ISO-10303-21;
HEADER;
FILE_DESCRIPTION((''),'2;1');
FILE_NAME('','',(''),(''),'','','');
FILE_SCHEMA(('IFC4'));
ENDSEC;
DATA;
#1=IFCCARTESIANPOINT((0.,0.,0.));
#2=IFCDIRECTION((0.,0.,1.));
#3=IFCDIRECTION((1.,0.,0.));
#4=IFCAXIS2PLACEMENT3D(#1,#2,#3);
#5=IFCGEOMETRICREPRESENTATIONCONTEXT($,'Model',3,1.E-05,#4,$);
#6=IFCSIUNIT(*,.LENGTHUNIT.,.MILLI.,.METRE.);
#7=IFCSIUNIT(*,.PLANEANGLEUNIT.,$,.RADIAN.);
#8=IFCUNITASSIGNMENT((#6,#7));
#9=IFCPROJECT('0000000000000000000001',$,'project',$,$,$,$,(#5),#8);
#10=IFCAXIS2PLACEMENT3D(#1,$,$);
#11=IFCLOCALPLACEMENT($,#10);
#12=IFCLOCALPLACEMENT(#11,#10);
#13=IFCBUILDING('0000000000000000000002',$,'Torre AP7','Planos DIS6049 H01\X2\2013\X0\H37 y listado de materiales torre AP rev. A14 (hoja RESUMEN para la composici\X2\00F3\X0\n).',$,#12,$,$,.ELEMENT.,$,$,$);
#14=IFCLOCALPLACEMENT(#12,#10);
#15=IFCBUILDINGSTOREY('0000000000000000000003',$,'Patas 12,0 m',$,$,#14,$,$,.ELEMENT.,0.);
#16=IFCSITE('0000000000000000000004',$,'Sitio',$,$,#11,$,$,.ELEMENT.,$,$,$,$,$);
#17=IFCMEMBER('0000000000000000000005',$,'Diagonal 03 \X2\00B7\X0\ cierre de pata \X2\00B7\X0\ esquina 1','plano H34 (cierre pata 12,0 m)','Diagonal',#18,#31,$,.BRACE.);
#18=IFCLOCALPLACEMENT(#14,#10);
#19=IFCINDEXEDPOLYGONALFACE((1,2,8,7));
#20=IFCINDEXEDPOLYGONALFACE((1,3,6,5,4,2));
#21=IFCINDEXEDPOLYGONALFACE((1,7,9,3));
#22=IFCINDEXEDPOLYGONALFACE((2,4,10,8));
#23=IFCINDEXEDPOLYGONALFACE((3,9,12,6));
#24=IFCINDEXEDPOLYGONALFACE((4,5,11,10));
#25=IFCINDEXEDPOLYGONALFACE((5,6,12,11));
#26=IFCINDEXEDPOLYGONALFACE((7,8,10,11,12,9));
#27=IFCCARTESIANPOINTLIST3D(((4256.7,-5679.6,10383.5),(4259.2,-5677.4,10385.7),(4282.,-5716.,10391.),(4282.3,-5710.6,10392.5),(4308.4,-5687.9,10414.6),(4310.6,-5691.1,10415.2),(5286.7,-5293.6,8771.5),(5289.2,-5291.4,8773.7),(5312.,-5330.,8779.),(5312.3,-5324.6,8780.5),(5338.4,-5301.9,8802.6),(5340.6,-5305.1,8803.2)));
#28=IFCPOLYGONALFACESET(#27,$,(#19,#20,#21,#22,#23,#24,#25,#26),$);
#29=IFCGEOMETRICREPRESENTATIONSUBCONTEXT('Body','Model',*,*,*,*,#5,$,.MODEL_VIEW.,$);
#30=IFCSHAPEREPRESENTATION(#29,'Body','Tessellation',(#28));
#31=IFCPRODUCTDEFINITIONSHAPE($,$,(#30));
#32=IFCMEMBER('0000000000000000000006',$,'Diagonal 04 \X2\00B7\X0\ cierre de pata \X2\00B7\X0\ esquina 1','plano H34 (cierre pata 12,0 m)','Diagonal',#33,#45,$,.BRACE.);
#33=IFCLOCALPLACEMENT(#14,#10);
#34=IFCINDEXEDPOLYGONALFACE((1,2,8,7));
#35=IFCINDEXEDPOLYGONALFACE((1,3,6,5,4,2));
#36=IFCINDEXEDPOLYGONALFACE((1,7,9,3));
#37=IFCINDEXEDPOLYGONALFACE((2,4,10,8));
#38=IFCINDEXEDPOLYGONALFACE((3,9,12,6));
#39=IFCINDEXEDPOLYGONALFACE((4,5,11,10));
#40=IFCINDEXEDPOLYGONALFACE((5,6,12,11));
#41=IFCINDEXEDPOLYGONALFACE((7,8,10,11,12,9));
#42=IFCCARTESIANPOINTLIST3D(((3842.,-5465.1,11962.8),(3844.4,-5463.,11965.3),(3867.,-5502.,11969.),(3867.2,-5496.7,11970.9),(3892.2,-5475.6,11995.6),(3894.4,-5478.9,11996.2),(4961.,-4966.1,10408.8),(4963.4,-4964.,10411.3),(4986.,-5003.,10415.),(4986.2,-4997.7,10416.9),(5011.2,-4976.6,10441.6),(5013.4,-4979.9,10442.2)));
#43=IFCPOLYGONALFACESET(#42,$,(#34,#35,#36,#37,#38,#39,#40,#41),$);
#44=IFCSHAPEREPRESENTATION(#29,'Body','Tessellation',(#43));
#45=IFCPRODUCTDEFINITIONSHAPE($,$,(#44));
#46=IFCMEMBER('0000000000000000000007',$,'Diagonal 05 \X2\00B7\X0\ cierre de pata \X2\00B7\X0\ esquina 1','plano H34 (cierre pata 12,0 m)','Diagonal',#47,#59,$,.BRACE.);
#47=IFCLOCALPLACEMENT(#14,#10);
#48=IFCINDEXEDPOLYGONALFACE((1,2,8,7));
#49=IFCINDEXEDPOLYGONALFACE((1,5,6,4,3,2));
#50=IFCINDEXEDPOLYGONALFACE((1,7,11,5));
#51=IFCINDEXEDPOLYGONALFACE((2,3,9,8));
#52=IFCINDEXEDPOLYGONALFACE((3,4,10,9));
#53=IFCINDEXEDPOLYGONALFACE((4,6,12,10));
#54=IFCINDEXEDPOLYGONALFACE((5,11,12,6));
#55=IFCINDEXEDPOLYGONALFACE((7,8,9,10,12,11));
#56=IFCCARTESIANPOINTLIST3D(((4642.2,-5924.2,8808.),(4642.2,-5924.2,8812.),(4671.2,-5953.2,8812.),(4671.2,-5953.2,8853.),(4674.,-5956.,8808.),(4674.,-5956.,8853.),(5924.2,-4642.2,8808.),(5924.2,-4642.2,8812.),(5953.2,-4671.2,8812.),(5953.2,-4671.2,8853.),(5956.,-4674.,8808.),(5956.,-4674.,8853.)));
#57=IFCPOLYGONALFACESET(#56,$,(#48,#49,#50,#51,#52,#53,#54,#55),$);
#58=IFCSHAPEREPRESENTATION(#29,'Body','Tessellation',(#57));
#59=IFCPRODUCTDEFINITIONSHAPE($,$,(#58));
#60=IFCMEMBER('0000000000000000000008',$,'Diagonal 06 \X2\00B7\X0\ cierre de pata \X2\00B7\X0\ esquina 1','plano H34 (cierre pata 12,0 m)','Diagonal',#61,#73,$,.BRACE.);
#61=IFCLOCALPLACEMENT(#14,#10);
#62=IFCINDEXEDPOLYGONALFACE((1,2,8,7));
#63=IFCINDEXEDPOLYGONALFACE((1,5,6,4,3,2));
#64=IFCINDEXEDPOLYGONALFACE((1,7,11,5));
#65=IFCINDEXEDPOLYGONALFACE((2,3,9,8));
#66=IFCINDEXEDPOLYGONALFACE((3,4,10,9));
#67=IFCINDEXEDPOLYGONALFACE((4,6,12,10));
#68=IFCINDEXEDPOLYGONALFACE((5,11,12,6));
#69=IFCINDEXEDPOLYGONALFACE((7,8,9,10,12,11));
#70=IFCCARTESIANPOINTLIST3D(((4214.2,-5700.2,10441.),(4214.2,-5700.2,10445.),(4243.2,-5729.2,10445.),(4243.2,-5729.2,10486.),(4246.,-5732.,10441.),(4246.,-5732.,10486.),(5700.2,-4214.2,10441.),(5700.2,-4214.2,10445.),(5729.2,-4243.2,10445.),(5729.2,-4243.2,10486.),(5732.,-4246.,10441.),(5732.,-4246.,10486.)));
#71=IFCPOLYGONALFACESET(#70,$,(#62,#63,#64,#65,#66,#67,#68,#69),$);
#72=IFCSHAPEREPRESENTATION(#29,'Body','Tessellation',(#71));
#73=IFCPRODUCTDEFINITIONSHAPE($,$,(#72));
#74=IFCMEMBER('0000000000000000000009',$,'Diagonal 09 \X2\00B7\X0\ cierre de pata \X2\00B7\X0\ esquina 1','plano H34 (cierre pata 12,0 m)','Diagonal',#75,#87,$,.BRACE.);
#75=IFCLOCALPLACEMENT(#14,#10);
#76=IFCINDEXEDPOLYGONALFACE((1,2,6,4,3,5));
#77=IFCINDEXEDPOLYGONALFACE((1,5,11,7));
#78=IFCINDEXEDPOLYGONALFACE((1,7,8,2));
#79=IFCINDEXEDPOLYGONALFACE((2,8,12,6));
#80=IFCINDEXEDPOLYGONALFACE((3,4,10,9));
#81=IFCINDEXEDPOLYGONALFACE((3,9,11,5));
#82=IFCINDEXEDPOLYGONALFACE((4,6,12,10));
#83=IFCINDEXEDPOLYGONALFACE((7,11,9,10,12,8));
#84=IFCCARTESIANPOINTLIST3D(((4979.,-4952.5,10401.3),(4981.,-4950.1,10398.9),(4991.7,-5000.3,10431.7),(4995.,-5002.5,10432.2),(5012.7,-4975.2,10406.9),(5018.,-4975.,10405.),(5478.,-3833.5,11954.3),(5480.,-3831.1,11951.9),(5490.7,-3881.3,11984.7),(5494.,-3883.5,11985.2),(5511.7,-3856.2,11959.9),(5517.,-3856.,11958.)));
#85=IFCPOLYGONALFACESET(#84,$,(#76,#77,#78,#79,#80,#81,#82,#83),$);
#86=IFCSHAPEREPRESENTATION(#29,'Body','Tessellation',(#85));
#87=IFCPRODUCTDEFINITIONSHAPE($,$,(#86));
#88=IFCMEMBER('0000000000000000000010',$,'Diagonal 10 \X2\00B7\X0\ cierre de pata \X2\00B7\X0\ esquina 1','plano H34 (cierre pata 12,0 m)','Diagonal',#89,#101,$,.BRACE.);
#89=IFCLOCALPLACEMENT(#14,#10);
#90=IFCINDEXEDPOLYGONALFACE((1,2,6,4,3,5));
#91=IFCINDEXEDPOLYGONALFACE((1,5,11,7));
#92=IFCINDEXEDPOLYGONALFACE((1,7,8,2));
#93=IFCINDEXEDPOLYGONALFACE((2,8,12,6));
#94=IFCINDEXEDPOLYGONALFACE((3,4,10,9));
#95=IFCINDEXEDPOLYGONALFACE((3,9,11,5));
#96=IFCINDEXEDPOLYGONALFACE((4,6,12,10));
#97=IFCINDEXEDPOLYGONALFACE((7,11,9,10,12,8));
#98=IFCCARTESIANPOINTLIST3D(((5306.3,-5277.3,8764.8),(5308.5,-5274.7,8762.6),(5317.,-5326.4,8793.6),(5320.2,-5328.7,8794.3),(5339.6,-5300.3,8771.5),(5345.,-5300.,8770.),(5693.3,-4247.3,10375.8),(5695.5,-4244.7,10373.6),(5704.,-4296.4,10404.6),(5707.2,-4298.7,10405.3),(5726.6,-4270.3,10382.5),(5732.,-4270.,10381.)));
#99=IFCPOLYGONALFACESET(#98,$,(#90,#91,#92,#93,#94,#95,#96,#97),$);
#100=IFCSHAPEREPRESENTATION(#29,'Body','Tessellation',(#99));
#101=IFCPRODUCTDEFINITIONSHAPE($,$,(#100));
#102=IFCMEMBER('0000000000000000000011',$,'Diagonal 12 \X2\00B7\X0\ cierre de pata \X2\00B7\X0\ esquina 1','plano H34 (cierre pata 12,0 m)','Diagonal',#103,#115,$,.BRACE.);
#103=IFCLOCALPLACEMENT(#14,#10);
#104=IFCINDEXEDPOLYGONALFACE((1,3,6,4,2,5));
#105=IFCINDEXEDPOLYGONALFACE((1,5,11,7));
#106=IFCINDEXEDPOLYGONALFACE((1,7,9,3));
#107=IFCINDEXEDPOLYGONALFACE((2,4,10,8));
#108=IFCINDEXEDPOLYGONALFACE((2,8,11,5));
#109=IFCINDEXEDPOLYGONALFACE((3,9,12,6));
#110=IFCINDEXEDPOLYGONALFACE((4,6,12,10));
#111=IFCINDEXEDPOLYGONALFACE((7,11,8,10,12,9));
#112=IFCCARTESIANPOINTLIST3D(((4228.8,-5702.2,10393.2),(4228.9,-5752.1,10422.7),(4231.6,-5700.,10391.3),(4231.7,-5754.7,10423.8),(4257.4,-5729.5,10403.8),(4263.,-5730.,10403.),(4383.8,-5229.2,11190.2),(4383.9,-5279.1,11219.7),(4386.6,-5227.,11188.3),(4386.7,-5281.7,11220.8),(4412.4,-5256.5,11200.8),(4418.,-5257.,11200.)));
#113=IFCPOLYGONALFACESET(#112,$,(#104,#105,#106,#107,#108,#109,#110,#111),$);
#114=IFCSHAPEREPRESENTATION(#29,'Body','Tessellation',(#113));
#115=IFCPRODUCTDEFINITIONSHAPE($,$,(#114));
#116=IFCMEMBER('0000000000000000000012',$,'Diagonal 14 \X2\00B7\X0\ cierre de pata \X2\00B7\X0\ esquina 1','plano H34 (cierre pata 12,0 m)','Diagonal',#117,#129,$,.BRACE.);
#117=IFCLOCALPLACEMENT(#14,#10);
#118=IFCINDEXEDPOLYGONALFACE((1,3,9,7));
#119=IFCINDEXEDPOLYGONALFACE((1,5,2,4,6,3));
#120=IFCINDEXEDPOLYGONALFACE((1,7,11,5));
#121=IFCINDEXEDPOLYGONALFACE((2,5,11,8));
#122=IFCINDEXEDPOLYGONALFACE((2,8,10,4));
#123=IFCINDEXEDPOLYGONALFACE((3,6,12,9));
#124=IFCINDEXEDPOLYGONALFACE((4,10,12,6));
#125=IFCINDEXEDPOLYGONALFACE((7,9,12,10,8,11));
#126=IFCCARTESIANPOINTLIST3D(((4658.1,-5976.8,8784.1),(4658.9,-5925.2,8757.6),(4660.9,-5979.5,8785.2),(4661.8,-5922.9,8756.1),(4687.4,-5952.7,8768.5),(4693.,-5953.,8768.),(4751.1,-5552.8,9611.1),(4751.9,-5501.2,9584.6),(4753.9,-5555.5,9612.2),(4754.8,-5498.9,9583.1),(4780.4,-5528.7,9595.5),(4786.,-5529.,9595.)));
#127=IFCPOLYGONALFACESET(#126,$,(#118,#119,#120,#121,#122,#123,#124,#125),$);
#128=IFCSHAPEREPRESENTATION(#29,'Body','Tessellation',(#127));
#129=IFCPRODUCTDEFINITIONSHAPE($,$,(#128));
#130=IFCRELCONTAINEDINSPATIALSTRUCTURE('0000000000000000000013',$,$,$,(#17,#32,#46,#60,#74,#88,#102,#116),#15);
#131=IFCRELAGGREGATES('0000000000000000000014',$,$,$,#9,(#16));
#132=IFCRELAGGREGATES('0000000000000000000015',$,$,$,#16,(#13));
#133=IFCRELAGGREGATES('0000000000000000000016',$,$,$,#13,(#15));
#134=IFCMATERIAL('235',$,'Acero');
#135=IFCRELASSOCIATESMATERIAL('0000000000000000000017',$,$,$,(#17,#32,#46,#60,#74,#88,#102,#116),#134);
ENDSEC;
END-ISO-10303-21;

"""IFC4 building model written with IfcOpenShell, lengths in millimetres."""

from ifc_helpers import new_model, si_unit, frame, frame_2d, origin, origin_with_axes, place, context, subcontext, project, spatial, l_section, extrude, material, element, save


model = new_model("IFC4")

# Units and contexts
model_context = context("Model", 3, precision=1e-05, world=origin_with_axes())
body_context = subcontext(model_context, "Body", "Model", "MODEL_VIEW")
ifc_project = project(units=[si_unit("LENGTHUNIT", "METRE", prefix="MILLI"), si_unit("PLANEANGLEUNIT", "RADIAN")], contexts=[model_context])

# Site, building, storey
site_placement = place(None, origin())
site = spatial("IfcSite", under=ifc_project, at=site_placement, Name="Sitio", CompositionType="ELEMENT")
building_placement = place(site_placement, origin())
building = spatial("IfcBuilding", under=site, at=building_placement, Name="Torre AP7", Description="Planos DIS6049 H01–H37 y listado de materiales torre AP rev. A14 (hoja RESUMEN para la composición).", CompositionType="ELEMENT")
storey_placement = place(building_placement, origin())
storey = spatial("IfcBuildingStorey", under=building, at=storey_placement, Name="Patas 12,0 m", CompositionType="ELEMENT", Elevation=0.0)

# Members
ifc_material_1 = material(Name="235", Category="Acero")
member_1_placement = place(storey_placement, frame((4282.0, -5716.0, 10391.0), z_axis=(0.527793, 0.197794, -0.826022), x_axis=(-0.562895, 0.809734, -0.165772)))
element("IfcMember", 1, at=member_1_placement, inside=storey, material=ifc_material_1, Name="Diagonal 03 · cierre de pata · esquina 1", Description="plano H34 (cierre pata 12,0 m)", ObjectType="Diagonal", PredefinedType="BRACE", context=body_context, shape_type="SweptSolid", body=[
    extrude(l_section(Depth=45.0, Width=45.0, Thickness=4.0, at=frame_2d((22.5, 22.5))), None, (0.0, 0.0, 1.0), 1951.5),
])
member_2_placement = place(storey_placement, frame((3867.0, -5502.0, 11969.0), z_axis=(0.565463, 0.252159, -0.785281), x_axis=(-0.55564, 0.820098, -0.136764)))
element("IfcMember", 2, at=member_2_placement, inside=storey, material=ifc_material_1, Name="Diagonal 04 · cierre de pata · esquina 1", Description="plano H34 (cierre pata 12,0 m)", ObjectType="Diagonal", PredefinedType="BRACE", context=body_context, shape_type="SweptSolid", body=[
    extrude(l_section(Depth=45.0, Width=45.0, Thickness=4.0, at=frame_2d((22.5, 22.5))), None, (0.0, 0.0, 1.0), 1978.9),
])
member_3_placement = place(storey_placement, frame((4674.0, -5956.0, 8808.0), z_axis=(0.707107, 0.707107, 0.0), x_axis=(-0.707107, 0.707107, 0.0)))
element("IfcMember", 3, at=member_3_placement, inside=storey, material=ifc_material_1, Name="Diagonal 05 · cierre de pata · esquina 1", Description="plano H34 (cierre pata 12,0 m)", ObjectType="Diagonal", PredefinedType="BRACE", context=body_context, shape_type="SweptSolid", body=[
    extrude(l_section(Depth=45.0, Width=45.0, Thickness=4.0, at=frame_2d((22.5, 22.5))), None, (0.0, 0.0, 1.0), 1813.0),
])
member_4_placement = place(storey_placement, frame((4246.0, -5732.0, 10441.0), z_axis=(0.707107, 0.707107, 0.0), x_axis=(-0.707107, 0.707107, 0.0)))
element("IfcMember", 4, at=member_4_placement, inside=storey, material=ifc_material_1, Name="Diagonal 06 · cierre de pata · esquina 1", Description="plano H34 (cierre pata 12,0 m)", ObjectType="Diagonal", PredefinedType="BRACE", context=body_context, shape_type="SweptSolid", body=[
    extrude(l_section(Depth=45.0, Width=45.0, Thickness=4.0, at=frame_2d((22.5, 22.5))), None, (0.0, 0.0, 1.0), 2101.5),
])
member_5_placement = place(storey_placement, frame((5018.0, -4975.0, 10405.0), z_axis=(0.252259, 0.565688, 0.785088), x_axis=(-0.821233, 0.554271, -0.135501)))
element("IfcMember", 5, at=member_5_placement, inside=storey, material=ifc_material_1, Name="Diagonal 09 · cierre de pata · esquina 1", Description="plano H34 (cierre pata 12,0 m)", ObjectType="Diagonal", PredefinedType="BRACE", context=body_context, shape_type="SweptSolid", body=[
    extrude(l_section(Depth=45.0, Width=45.0, Thickness=4.0, at=frame_2d((22.5, 22.5))), None, (0.0, 0.0, 1.0), 1978.1),
])
member_6_placement = place(storey_placement, frame((5345.0, -5300.0, 8770.0), z_axis=(0.198371, 0.527963, 0.825775), x_axis=(-0.810974, 0.561563, -0.164223)))
element("IfcMember", 6, at=member_6_placement, inside=storey, material=ifc_material_1, Name="Diagonal 10 · cierre de pata · esquina 1", Description="plano H34 (cierre pata 12,0 m)", ObjectType="Diagonal", PredefinedType="BRACE", context=body_context, shape_type="SweptSolid", body=[
    extrude(l_section(Depth=45.0, Width=45.0, Thickness=4.0, at=frame_2d((22.5, 22.5))), None, (0.0, 0.0, 1.0), 1950.9),
])
member_7_placement = place(storey_placement, frame((4263.0, -5730.0, 10403.0), z_axis=(0.164953, 0.503373, 0.848178), x_axis=(-0.698843, 0.666489, -0.259634)))
element("IfcMember", 7, at=member_7_placement, inside=storey, material=ifc_material_1, Name="Diagonal 12 · cierre de pata · esquina 1", Description="plano H34 (cierre pata 12,0 m)", ObjectType="Diagonal", PredefinedType="BRACE", context=body_context, shape_type="SweptSolid", body=[
    extrude(l_section(Depth=45.0, Width=45.0, Thickness=4.0, at=frame_2d((22.5, 22.5))), None, (0.0, 0.0, 1.0), 939.7),
])
member_8_placement = place(storey_placement, frame((4693.0, -5953.0, 8768.0), z_axis=(0.099572, 0.453962, 0.88544), x_axis=(-0.694328, 0.669105, -0.264967)))
element("IfcMember", 8, at=member_8_placement, inside=storey, material=ifc_material_1, Name="Diagonal 14 · cierre de pata · esquina 1", Description="plano H34 (cierre pata 12,0 m)", ObjectType="Diagonal", PredefinedType="BRACE", context=body_context, shape_type="SweptSolid", body=[
    extrude(l_section(Depth=45.0, Width=45.0, Thickness=4.0, at=frame_2d((22.5, 22.5))), None, (0.0, 0.0, 1.0), 934.0),
])

save(model, "model.ifc")
